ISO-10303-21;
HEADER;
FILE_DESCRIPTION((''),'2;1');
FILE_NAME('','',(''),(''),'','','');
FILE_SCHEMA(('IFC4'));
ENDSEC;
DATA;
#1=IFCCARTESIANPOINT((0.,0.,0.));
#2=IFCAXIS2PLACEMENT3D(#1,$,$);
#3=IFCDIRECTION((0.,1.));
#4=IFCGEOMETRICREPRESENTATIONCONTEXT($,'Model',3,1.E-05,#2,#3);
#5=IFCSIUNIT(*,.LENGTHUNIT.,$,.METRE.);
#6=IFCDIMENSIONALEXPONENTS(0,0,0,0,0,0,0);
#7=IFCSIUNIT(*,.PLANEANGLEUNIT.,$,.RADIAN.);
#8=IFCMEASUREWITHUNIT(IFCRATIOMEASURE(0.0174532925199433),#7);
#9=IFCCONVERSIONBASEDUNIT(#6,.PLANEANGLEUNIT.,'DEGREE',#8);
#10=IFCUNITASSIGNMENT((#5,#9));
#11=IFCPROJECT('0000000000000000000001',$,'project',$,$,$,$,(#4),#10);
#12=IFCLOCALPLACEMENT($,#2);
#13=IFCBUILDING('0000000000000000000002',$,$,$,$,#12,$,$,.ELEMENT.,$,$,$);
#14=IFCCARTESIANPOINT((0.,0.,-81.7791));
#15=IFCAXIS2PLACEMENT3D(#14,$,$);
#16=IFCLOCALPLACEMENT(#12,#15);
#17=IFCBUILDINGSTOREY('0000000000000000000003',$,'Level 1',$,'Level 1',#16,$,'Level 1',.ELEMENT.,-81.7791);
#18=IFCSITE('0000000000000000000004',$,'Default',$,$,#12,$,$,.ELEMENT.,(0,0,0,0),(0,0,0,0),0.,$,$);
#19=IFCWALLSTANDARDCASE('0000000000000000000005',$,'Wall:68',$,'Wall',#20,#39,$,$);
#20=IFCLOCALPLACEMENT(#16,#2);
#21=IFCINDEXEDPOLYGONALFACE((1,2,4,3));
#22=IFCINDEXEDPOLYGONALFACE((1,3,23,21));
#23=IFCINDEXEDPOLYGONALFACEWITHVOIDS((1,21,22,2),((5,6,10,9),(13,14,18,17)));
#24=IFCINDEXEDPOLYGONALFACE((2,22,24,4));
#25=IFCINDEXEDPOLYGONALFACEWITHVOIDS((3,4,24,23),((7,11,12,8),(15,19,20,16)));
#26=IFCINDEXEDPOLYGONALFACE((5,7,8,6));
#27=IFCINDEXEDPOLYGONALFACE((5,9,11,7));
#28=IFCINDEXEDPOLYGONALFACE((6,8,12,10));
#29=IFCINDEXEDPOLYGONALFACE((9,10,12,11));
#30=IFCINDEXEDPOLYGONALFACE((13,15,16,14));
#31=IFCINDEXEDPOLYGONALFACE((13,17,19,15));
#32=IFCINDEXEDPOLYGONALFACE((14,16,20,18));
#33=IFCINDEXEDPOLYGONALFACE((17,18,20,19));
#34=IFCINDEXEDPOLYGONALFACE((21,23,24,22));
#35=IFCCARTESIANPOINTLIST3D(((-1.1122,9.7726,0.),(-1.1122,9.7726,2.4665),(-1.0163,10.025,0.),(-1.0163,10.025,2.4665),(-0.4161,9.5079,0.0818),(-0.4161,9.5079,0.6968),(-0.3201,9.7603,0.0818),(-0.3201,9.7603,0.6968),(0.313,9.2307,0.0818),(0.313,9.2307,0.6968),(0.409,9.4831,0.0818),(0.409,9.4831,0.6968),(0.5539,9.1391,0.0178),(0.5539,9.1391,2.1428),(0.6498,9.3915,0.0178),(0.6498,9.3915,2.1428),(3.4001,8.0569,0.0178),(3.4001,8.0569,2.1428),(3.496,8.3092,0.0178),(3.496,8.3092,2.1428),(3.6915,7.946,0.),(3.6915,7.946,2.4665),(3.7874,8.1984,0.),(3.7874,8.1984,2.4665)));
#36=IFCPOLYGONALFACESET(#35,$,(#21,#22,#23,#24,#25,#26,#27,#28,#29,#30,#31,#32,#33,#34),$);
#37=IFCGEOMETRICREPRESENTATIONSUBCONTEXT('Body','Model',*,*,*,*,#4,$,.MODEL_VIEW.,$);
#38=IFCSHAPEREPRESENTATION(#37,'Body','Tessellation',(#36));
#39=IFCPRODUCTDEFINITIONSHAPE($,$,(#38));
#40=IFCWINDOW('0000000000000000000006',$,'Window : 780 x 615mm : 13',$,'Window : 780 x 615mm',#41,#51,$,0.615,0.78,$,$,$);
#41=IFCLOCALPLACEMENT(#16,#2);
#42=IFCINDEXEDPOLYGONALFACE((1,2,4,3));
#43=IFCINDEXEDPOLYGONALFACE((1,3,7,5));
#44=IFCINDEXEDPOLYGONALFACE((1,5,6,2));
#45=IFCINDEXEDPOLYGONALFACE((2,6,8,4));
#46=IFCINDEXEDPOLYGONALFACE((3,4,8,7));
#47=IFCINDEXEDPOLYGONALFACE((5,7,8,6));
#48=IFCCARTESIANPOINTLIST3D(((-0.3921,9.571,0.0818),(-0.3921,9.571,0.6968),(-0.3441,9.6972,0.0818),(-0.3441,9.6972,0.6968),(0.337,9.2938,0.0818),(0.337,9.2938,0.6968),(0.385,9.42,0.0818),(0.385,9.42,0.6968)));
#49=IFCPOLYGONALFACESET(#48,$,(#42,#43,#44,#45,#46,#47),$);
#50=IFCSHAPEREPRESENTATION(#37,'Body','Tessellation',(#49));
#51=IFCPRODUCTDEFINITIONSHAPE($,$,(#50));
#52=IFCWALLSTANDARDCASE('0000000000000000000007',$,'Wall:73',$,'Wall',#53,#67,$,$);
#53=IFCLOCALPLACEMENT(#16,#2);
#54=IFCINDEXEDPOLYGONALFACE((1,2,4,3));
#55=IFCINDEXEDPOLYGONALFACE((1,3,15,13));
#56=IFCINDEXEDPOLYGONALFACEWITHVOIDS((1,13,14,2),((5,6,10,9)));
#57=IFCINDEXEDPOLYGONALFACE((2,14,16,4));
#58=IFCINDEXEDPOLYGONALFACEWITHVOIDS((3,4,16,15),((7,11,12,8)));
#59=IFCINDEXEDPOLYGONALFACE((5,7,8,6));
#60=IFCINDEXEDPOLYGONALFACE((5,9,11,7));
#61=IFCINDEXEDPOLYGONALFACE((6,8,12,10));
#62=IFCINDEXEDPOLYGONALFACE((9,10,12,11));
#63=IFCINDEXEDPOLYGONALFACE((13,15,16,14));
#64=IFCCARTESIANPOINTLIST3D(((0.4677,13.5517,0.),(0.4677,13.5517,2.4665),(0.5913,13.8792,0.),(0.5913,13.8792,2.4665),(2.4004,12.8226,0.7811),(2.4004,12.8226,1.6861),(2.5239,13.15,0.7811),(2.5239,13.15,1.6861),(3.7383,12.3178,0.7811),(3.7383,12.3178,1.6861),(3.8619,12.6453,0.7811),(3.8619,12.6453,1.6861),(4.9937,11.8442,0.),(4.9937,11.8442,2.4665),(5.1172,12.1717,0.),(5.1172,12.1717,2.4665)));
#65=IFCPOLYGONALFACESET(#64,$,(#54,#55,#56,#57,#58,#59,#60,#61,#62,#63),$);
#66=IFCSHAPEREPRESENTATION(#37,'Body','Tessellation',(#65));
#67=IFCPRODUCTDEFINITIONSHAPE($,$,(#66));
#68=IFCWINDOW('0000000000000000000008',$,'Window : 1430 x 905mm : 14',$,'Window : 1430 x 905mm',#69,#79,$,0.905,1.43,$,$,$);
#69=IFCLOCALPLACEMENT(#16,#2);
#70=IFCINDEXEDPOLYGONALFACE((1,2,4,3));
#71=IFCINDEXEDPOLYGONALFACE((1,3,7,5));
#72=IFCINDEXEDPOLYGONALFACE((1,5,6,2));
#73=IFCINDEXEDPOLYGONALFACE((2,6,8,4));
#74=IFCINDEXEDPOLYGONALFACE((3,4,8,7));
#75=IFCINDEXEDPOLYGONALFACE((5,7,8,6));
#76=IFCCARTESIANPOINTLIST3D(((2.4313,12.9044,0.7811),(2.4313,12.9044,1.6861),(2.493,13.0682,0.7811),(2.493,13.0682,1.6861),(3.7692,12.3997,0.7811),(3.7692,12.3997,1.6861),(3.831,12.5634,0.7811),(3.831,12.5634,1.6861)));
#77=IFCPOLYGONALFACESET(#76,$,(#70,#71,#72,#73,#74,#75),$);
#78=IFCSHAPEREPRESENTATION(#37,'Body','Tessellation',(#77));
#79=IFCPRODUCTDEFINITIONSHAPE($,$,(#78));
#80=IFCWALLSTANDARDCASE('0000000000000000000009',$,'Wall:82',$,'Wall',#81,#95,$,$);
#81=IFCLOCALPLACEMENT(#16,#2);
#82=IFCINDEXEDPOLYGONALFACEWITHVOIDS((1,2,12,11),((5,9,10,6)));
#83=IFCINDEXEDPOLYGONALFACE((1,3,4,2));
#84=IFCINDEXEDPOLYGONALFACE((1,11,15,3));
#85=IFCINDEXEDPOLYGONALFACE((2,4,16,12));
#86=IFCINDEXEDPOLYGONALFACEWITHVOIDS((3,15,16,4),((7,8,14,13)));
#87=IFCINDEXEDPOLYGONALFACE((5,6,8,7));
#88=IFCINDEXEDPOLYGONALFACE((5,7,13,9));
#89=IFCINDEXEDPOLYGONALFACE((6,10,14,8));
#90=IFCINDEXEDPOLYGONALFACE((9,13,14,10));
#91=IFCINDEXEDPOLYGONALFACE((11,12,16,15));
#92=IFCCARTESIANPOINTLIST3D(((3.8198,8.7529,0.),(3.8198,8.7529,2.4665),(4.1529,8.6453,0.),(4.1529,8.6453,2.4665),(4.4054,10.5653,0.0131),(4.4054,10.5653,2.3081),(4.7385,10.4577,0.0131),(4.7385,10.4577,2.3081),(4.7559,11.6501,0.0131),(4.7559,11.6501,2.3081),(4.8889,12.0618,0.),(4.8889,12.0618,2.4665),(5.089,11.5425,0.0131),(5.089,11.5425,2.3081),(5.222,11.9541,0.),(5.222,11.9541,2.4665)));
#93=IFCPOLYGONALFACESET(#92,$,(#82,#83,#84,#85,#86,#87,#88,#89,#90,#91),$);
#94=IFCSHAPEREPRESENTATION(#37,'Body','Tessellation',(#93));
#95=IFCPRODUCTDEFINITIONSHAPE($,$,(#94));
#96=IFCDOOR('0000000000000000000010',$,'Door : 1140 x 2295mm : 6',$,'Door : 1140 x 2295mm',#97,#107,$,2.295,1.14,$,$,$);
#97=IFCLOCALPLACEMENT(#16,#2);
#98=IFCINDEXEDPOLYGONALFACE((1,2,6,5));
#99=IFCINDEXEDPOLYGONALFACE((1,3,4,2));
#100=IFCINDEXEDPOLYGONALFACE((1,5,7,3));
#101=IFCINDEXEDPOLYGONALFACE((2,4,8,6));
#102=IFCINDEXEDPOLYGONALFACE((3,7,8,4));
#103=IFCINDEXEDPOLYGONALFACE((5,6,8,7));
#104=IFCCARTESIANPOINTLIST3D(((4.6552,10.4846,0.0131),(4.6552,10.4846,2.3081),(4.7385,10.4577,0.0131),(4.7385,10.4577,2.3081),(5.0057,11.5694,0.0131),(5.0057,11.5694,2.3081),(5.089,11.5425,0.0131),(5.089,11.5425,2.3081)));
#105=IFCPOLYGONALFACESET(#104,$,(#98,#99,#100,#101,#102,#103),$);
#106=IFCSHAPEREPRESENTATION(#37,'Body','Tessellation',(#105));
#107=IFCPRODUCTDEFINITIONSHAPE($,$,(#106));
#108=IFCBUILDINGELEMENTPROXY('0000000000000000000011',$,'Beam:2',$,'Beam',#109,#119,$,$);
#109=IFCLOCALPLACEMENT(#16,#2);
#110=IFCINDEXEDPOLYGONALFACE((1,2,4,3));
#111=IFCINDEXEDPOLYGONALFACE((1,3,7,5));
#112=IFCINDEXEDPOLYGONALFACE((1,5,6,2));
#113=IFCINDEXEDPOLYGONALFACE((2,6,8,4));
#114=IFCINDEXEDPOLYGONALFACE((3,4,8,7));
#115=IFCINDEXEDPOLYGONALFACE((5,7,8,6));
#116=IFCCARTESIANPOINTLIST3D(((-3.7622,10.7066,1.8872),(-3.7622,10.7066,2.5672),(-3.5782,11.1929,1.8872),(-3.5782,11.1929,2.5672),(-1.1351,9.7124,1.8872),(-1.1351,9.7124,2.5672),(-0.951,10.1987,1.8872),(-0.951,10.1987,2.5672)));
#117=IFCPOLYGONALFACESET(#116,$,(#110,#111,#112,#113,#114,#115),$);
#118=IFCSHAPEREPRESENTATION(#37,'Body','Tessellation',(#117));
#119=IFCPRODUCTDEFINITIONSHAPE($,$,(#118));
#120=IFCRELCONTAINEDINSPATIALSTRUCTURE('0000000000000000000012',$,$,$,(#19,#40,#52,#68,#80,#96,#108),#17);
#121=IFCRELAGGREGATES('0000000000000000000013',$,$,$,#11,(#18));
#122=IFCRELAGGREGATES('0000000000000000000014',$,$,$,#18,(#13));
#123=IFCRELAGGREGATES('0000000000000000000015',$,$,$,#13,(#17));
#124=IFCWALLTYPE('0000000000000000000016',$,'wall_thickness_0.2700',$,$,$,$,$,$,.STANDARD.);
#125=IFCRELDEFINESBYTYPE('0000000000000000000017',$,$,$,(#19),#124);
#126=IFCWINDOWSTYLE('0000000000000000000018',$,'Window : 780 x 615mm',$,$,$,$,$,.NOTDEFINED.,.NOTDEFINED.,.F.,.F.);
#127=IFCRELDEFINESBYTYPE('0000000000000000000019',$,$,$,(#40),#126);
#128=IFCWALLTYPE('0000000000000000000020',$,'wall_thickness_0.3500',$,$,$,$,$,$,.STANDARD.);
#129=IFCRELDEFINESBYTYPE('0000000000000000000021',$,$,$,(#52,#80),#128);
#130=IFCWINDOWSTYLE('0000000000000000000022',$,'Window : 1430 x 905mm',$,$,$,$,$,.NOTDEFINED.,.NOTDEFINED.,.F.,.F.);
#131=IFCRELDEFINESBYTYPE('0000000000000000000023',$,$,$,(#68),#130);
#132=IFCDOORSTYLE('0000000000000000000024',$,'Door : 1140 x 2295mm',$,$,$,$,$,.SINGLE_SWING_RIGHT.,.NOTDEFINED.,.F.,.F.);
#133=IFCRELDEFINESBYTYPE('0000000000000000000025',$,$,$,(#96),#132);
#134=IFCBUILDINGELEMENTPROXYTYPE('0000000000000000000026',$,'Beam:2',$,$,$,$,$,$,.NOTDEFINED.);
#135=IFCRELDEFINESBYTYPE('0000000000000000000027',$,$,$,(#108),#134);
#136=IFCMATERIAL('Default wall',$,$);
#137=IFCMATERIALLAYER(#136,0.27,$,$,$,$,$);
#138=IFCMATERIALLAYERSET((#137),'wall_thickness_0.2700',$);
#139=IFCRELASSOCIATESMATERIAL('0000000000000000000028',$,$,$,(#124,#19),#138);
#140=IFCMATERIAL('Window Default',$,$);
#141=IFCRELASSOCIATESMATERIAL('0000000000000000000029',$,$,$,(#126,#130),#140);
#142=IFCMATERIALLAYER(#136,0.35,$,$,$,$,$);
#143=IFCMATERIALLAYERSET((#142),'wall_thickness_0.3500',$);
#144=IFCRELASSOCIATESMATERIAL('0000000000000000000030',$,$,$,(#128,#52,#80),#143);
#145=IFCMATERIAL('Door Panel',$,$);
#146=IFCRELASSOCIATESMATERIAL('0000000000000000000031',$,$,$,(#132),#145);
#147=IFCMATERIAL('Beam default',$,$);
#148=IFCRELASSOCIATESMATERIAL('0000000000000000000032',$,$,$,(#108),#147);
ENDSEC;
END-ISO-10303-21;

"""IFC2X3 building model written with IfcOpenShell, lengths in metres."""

from ifc_helpers import new_model, entity, si_unit, converted_unit, direction, frame, frame_2d, origin, origin_2d_with_axis, place, context, subcontext, project, spatial, polyline, rectangle, outline, extrude, source, transform, mapped, material, layer, layer_set, layer_usage, type_object, type_shapes, element, fill, save


model = new_model("IFC2X3")

# Units and contexts
model_context = context("Model", 3, precision=1e-05, world=origin(), true_north=direction((0.0, 1.0)))
body_context = subcontext(model_context, "Body", "Model", "MODEL_VIEW")
ifc_project = project(units=[si_unit("LENGTHUNIT", "METRE"), converted_unit("PLANEANGLEUNIT", "DEGREE", entity("IfcRatioMeasure", 0.0174532925199433), si_unit("PLANEANGLEUNIT", "RADIAN"), dimensions=[0, 0, 0, 0, 0, 0, 0])], contexts=[model_context])

# Site, building, storey
placement_1 = place(None, origin())
site = spatial("IfcSite", under=ifc_project, at=placement_1, Name="Default", CompositionType="ELEMENT", RefLatitude=(0, 0, 0, 0), RefLongitude=(0, 0, 0, 0), RefElevation=0.0)
building = spatial("IfcBuilding", under=site, at=placement_1, CompositionType="ELEMENT")
storey_placement = place(placement_1, frame((0.0, 0.0, -81.7791)))
storey = spatial("IfcBuildingStorey", under=building, at=storey_placement, Name="Level 1", ObjectType="Level 1", LongName="Level 1", CompositionType="ELEMENT", Elevation=-81.7791)

# Shared definitions
ifc_material_1 = material(Name="Default wall")

# Shared definitions
ifc_material_2 = material(Name="Window Default")

# Shared definitions
ifc_material_3 = material(Name="Door Panel")

# Wall, openings, window
ifc_layer_1 = layer(ifc_material_1, 0.27)
ifc_layer_set_1 = layer_set([ifc_layer_1], Name="wall_thickness_0.2700")
ifc_layer_usage_1 = layer_usage(ifc_layer_set_1, "AXIS2", "POSITIVE", -0.135)
wall_type_1 = type_object("IfcWallType", Name="wall_thickness_0.2700", PredefinedType="STANDARD", material=ifc_layer_set_1)
wall_1_placement = place(storey_placement, frame((-1.0643, 9.8988, 0.0), z_axis=(0.0, 0.0, 1.0), x_axis=(0.934707, -0.355419, 0.0)))
wall_1 = element("IfcWallStandardCase", 1, at=wall_1_placement, inside=storey, type_object=wall_type_1, material=ifc_layer_usage_1, Name="Wall:68", ObjectType="Wall", context=body_context, shape_type="SweptSolid", body=[
    extrude(outline(polyline([(5.1392, -0.135), (5.1392, 0.135), (0.0, 0.135), (0.0, -0.135), (5.1392, -0.135)])), origin(), (0.0, 0.0, 1.0), 2.4665),
])
opening_1_placement = place(wall_1_placement, frame((1.7825, -0.135, 0.0178)))
element("IfcOpeningElement", 2, at=opening_1_placement, cuts=wall_1, ObjectType="Opening", context=body_context, shape_type="SweptSolid", body=[
    extrude(rectangle(XDim=3.045, YDim=2.125, at=frame_2d((1.0625, 1.5225), x_axis=(0.0, 1.0))), frame((0.0, 0.0, 0.0), z_axis=(0.0, 1.0, 0.0), x_axis=(0.0, 0.0, 1.0)), (0.0, 0.0, 1.0), 0.27),
])
opening_2_placement = place(wall_1_placement, frame((0.7448, -0.135, 0.0818)))
opening_2 = element("IfcOpeningElement", 3, at=opening_2_placement, cuts=wall_1, ObjectType="Opening", context=body_context, shape_type="SweptSolid", body=[
    extrude(rectangle(XDim=0.78, YDim=0.615, at=frame_2d((0.3075, 0.39), x_axis=(0.0, 1.0))), frame((0.0, 0.0, 0.0), z_axis=(0.0, 1.0, 0.0), x_axis=(0.0, 0.0, 1.0)), (0.0, 0.0, 1.0), 0.27),
])
window_style_1 = type_object("IfcWindowStyle", Name="Window : 780 x 615mm", ConstructionType="NOTDEFINED", OperationType="NOTDEFINED", ParameterTakesPrecedence=False, Sizeable=False, material=ifc_material_2)
shared_shape_1 = source(origin(), body_context, "Body", "SweptSolid", [
    extrude(rectangle(XDim=0.135, YDim=0.78, at=origin_2d_with_axis()), frame((0.39, 0.135, 0.0), z_axis=(0.0, 0.0, 1.0), x_axis=(0.0, 1.0, 0.0)), (0.0, 0.0, 1.0), 0.615),
])
type_shapes(window_style_1, [shared_shape_1])
window_1_placement = place(opening_2_placement, origin())
window_1 = element("IfcWindow", 4, at=window_1_placement, inside=storey, type_object=window_style_1, Name="Window : 780 x 615mm : 13", ObjectType="Window : 780 x 615mm", OverallHeight=0.615, OverallWidth=0.78, context=body_context, shape_type="MappedRepresentation", body=[
    mapped(shared_shape_1, transform((0.0, 0.0, 0.0), scale=1.0)),
])
fill(opening_2, window_1)

# Wall, opening, window
ifc_layer_2 = layer(ifc_material_1, 0.35)
ifc_layer_set_2 = layer_set([ifc_layer_2], Name="wall_thickness_0.3500")
ifc_layer_usage_2 = layer_usage(ifc_layer_set_2, "AXIS2", "POSITIVE", -0.175)
wall_type_2 = type_object("IfcWallType", Name="wall_thickness_0.3500", PredefinedType="STANDARD", material=ifc_layer_set_2)
wall_2_placement = place(storey_placement, frame((0.5295, 13.7154, 0.0), z_axis=(0.0, 0.0, 1.0), x_axis=(0.935631, -0.35298, 0.0)))
wall_2 = element("IfcWallStandardCase", 5, at=wall_2_placement, inside=storey, type_object=wall_type_2, material=ifc_layer_usage_2, Name="Wall:73", ObjectType="Wall", context=body_context, shape_type="SweptSolid", body=[
    extrude(outline(polyline([(4.8373, -0.175), (4.8373, 0.175), (0.0, 0.175), (0.0, -0.175), (4.8373, -0.175)])), origin(), (0.0, 0.0, 1.0), 2.4665),
])
opening_3_placement = place(wall_2_placement, frame((2.0656, -0.175, 0.7811)))
opening_3 = element("IfcOpeningElement", 6, at=opening_3_placement, cuts=wall_2, ObjectType="Opening", context=body_context, shape_type="SweptSolid", body=[
    extrude(rectangle(XDim=1.43, YDim=0.905, at=frame_2d((0.4525, 0.715), x_axis=(0.0, 1.0))), frame((0.0, 0.0, 0.0), z_axis=(0.0, 1.0, 0.0), x_axis=(0.0, 0.0, 1.0)), (0.0, 0.0, 1.0), 0.35),
])
window_style_2 = type_object("IfcWindowStyle", Name="Window : 1430 x 905mm", ConstructionType="NOTDEFINED", OperationType="NOTDEFINED", ParameterTakesPrecedence=False, Sizeable=False, material=ifc_material_2)
shared_shape_2 = source(origin(), body_context, "Body", "SweptSolid", [
    extrude(rectangle(XDim=0.175, YDim=1.43, at=origin_2d_with_axis()), frame((0.715, 0.175, 0.0), z_axis=(0.0, 0.0, 1.0), x_axis=(0.0, 1.0, 0.0)), (0.0, 0.0, 1.0), 0.905),
])
type_shapes(window_style_2, [shared_shape_2])
window_2_placement = place(opening_3_placement, origin())
window_2 = element("IfcWindow", 7, at=window_2_placement, inside=storey, type_object=window_style_2, Name="Window : 1430 x 905mm : 14", ObjectType="Window : 1430 x 905mm", OverallHeight=0.905, OverallWidth=1.43, context=body_context, shape_type="MappedRepresentation", body=[
    mapped(shared_shape_2, transform((0.0, 0.0, 0.0), scale=1.0)),
])
fill(opening_3, window_2)

# Wall, opening, door
wall_3_placement = place(storey_placement, frame((5.0555, 12.0079, 0.0), z_axis=(0.0, 0.0, 1.0), x_axis=(-0.307459, -0.951561, 0.0)))
wall_3 = element("IfcWallStandardCase", 8, at=wall_3_placement, inside=storey, type_object=wall_type_2, material=ifc_layer_usage_2, Name="Wall:82", ObjectType="Wall", context=body_context, shape_type="SweptSolid", body=[
    extrude(outline(polyline([(3.4773, -0.175), (3.4773, 0.175), (0.0, 0.175), (0.0, -0.175), (3.4773, -0.175)])), origin(), (0.0, 0.0, 1.0), 2.4665),
])
opening_4_placement = place(wall_3_placement, frame((0.4326, -0.175, 0.0131)))
opening_4 = element("IfcOpeningElement", 9, at=opening_4_placement, cuts=wall_3, ObjectType="Opening", context=body_context, shape_type="SweptSolid", body=[
    extrude(rectangle(XDim=1.14, YDim=2.295, at=frame_2d((1.1475, 0.57), x_axis=(0.0, 1.0))), frame((0.0, 0.0, 0.0), z_axis=(0.0, 1.0, 0.0), x_axis=(0.0, 0.0, 1.0)), (0.0, 0.0, 1.0), 0.35),
])
door_style_1 = type_object("IfcDoorStyle", Name="Door : 1140 x 2295mm", ConstructionType="NOTDEFINED", OperationType="SINGLE_SWING_RIGHT", ParameterTakesPrecedence=False, Sizeable=False, material=ifc_material_3)
shared_shape_3 = source(origin(), body_context, "Body", "SweptSolid", [
    extrude(rectangle(XDim=0.0875, YDim=1.14, at=origin_2d_with_axis()), frame((0.57, 0.3062, 0.0), z_axis=(0.0, 0.0, 1.0), x_axis=(0.0, 1.0, 0.0)), (0.0, 0.0, 1.0), 2.295),
])
type_shapes(door_style_1, [shared_shape_3])
door_1_placement = place(opening_4_placement, origin())
door_1 = element("IfcDoor", 10, at=door_1_placement, inside=storey, type_object=door_style_1, Name="Door : 1140 x 2295mm : 6", ObjectType="Door : 1140 x 2295mm", OverallHeight=2.295, OverallWidth=1.14, context=body_context, shape_type="MappedRepresentation", body=[
    mapped(shared_shape_3, transform((0.0, 0.0, 0.0), scale=1.0)),
])
fill(opening_4, door_1)

# Building element proxy
ifc_material_4 = material(Name="Beam default")
building_element_proxy_type = type_object("IfcBuildingElementProxyType", Name="Beam:2", PredefinedType="NOTDEFINED")
shared_shape_4 = source(origin(), body_context, "Body", "SweptSolid", [
    extrude(outline(polyline([(2.809, -0.26), (2.809, 0.26), (0.0, 0.26), (0.0, -0.26), (2.809, -0.26)])), origin(), (0.0, 0.0, 1.0), 0.68),
])
type_shapes(building_element_proxy_type, [shared_shape_4])
placement_2 = place(placement_1, frame((0.0, 0.0, -79.8919)))
proxy_placement = place(placement_2, frame((-3.6702, 10.9498, 0.0), z_axis=(0.0, 0.0, 1.0), x_axis=(0.935269, -0.353936, 0.0)))
element("IfcBuildingElementProxy", 11, at=proxy_placement, inside=storey, type_object=building_element_proxy_type, material=ifc_material_4, Name="Beam:2", ObjectType="Beam", context=body_context, shape_type="MappedRepresentation", body=[
    mapped(shared_shape_4, transform((0.0, 0.0, 0.0), scale=1.0)),
])

save(model, "model.ifc")
